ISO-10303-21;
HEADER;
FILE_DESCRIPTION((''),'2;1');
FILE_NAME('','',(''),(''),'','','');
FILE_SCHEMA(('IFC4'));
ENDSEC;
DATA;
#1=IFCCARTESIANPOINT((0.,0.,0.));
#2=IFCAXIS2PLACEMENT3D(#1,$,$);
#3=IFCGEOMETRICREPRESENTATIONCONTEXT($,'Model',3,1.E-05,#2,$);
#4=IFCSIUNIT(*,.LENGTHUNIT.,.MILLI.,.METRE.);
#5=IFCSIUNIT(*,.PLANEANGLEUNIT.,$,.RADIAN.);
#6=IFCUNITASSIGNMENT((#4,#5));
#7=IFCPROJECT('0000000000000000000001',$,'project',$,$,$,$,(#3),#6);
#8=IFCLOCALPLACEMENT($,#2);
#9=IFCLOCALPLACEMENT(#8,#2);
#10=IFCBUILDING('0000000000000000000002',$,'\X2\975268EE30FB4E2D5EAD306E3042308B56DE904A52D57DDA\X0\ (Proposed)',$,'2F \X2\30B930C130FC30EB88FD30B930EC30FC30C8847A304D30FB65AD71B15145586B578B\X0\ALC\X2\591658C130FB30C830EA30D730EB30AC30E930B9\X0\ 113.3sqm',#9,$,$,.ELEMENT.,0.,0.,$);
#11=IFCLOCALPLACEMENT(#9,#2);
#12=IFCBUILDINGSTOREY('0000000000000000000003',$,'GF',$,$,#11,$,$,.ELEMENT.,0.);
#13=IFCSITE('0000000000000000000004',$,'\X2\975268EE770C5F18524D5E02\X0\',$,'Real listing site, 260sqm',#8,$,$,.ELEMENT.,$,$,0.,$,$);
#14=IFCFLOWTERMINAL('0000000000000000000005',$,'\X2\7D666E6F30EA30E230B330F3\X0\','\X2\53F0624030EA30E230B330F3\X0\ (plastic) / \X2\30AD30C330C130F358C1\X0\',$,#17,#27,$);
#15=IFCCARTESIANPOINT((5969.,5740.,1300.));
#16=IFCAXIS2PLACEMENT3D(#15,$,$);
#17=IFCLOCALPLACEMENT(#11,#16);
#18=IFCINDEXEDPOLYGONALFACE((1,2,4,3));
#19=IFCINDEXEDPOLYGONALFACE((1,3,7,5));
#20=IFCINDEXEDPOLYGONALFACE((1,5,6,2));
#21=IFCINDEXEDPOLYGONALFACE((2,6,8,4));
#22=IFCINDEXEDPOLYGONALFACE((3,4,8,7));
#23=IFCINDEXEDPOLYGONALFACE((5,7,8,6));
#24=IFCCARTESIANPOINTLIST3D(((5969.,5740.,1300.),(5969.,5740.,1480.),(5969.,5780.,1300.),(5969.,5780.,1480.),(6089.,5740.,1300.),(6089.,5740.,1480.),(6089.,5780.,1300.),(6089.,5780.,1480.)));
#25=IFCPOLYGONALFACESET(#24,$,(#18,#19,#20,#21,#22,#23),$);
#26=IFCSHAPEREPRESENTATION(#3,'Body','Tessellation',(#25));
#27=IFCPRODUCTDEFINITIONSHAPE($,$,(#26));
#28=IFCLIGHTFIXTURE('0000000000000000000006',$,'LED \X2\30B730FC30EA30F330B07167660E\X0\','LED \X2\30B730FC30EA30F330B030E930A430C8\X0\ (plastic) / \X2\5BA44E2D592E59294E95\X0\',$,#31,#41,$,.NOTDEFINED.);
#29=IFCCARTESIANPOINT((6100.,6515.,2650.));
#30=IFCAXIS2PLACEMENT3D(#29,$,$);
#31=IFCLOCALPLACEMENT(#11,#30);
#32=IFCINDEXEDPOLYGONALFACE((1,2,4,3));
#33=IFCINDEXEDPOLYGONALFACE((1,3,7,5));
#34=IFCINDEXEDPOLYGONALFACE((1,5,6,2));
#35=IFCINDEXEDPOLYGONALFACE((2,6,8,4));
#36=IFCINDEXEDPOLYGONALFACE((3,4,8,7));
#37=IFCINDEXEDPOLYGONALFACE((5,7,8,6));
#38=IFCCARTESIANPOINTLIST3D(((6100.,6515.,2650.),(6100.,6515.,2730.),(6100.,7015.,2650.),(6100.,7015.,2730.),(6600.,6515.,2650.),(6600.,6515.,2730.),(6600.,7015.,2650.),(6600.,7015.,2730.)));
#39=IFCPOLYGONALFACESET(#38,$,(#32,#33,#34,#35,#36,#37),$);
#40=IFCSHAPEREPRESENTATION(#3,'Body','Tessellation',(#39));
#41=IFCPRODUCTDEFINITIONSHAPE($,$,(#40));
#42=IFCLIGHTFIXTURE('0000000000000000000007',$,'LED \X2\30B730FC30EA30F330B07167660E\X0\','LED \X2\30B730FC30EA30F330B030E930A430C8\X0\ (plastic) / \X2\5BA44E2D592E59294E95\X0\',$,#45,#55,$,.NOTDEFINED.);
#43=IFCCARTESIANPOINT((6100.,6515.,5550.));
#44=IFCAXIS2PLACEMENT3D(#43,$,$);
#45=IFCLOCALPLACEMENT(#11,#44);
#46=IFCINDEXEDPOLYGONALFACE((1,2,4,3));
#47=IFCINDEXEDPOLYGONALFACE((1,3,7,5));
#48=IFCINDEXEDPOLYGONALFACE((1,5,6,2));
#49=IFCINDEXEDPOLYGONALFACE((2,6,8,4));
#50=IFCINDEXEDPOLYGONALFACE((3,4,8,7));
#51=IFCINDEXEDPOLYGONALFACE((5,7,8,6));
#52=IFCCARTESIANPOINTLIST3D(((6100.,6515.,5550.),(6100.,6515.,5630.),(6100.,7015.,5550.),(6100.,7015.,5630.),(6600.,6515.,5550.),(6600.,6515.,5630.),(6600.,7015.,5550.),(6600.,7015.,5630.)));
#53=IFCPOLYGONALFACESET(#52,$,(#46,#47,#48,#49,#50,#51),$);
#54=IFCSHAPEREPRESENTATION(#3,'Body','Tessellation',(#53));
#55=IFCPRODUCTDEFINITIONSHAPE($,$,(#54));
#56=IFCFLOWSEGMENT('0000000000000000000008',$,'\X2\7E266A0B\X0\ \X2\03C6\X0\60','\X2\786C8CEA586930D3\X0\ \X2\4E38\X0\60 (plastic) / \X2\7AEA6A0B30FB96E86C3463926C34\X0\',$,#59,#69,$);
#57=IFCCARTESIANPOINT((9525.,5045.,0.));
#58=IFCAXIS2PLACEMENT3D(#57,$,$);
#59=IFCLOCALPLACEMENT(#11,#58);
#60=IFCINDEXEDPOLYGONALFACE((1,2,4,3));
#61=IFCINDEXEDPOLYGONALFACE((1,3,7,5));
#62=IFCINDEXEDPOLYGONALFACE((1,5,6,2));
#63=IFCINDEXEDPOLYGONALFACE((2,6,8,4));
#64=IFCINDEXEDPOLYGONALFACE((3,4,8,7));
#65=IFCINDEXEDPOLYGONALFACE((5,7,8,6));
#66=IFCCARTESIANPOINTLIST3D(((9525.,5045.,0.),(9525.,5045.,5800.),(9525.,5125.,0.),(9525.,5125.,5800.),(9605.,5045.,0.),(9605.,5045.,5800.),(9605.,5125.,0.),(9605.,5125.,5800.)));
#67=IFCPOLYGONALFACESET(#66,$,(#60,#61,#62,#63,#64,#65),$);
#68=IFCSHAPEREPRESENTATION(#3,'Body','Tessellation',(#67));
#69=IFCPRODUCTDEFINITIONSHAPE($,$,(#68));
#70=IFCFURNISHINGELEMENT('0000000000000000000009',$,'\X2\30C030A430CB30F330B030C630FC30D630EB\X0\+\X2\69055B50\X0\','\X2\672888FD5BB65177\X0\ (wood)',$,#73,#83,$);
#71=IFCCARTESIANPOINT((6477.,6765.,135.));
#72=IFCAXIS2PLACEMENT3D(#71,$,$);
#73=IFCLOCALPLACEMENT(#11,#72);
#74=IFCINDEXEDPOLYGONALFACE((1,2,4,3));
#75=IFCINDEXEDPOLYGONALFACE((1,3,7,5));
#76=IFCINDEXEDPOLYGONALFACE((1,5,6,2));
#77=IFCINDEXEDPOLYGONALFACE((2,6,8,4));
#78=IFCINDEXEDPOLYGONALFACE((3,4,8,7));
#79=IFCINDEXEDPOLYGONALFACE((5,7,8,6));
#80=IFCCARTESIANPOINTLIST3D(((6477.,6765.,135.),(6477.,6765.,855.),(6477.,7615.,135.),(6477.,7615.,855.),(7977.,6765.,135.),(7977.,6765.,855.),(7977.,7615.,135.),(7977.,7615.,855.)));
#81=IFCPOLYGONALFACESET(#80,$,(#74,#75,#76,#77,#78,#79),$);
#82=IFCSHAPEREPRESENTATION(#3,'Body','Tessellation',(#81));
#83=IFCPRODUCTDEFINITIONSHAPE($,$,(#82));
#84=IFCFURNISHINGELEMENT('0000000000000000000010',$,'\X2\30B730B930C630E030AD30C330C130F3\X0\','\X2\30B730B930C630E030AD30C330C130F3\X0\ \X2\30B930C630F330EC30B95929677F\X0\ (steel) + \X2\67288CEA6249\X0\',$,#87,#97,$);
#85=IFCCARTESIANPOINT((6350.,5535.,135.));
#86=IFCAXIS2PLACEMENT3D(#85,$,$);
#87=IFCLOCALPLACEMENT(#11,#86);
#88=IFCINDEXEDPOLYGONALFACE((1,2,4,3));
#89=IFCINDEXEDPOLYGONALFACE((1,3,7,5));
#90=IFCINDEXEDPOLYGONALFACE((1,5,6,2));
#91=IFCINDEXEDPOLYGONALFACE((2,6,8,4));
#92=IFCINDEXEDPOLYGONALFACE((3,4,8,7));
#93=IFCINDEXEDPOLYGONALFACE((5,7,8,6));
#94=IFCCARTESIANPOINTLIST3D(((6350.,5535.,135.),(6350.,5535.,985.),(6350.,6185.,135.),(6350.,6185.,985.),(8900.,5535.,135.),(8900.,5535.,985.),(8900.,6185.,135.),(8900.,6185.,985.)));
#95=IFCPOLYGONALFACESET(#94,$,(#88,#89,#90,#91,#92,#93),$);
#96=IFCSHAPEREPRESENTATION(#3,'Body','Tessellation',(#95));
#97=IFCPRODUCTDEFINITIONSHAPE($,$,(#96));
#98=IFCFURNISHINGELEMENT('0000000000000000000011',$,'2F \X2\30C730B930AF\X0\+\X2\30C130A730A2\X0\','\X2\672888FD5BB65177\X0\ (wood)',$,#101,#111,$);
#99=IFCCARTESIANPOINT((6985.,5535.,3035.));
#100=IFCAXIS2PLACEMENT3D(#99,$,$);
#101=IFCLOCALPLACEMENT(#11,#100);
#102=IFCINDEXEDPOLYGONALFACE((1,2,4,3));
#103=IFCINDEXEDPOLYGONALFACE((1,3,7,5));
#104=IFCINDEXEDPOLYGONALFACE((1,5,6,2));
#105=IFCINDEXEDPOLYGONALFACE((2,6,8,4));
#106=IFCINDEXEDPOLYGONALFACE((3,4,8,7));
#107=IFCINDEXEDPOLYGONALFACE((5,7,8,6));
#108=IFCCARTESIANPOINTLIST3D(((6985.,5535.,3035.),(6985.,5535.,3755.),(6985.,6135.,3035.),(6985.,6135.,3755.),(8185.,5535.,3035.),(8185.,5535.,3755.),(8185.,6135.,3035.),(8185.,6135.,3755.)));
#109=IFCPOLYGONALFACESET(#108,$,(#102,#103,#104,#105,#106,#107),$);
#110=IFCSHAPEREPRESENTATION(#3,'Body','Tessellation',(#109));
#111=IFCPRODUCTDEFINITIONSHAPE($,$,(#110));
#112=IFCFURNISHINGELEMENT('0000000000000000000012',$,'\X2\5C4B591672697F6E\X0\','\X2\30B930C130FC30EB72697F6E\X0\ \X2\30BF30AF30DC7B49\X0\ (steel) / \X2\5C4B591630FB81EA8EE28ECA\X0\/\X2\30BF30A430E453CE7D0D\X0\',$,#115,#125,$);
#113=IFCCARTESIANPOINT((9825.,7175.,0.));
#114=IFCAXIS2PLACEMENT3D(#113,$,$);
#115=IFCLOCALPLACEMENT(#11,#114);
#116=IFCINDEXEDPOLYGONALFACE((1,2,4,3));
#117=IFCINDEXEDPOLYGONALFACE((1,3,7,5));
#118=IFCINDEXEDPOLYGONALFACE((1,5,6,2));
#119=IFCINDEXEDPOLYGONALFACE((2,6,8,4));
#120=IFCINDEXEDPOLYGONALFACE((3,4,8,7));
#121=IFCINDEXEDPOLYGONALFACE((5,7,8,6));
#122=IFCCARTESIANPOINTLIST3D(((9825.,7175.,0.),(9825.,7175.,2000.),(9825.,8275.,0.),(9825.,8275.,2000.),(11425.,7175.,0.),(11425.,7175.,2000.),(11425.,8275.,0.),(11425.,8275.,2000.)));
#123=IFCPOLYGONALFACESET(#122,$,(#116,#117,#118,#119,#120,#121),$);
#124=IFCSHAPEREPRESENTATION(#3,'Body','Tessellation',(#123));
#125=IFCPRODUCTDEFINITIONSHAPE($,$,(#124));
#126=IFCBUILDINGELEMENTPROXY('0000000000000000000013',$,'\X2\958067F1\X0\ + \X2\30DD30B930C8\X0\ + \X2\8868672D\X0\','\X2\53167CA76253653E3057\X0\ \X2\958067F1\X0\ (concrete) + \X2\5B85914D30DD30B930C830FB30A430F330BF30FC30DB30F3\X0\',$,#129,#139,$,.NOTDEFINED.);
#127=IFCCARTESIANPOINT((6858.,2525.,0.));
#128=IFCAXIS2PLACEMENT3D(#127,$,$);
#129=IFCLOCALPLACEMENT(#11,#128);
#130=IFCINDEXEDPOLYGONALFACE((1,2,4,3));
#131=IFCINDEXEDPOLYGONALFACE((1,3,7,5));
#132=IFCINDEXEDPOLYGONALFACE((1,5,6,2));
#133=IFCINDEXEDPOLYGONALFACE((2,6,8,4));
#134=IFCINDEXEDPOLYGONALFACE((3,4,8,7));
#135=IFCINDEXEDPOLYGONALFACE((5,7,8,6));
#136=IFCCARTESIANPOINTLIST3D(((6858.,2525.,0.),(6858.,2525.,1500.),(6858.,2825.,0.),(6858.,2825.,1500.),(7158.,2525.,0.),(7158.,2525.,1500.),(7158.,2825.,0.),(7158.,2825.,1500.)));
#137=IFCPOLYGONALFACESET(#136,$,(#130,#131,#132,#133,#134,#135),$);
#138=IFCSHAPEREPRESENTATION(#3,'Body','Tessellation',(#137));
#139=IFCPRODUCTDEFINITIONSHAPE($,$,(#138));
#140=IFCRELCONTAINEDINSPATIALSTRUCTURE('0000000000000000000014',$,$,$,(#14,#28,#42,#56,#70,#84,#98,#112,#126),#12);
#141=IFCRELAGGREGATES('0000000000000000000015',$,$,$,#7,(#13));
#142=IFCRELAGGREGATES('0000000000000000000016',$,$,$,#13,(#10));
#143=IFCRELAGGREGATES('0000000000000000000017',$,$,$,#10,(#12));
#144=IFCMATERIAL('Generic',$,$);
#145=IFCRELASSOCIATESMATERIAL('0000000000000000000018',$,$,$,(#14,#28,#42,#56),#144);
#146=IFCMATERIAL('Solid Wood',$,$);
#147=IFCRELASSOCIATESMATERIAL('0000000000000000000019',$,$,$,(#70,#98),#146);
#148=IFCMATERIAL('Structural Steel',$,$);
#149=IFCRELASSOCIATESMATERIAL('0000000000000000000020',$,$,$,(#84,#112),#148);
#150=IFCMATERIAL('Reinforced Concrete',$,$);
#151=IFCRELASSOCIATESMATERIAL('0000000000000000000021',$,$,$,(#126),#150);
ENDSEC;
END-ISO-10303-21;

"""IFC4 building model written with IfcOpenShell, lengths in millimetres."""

from ifc_helpers import new_model, si_unit, frame, frame_2d, origin, place, context, project, spatial, rectangle, extrude, material, element, save


model = new_model("IFC4")

# Units and contexts
model_context = context("Model", 3, precision=1e-05, world=origin())
ifc_project = project(units=[si_unit("LENGTHUNIT", "METRE", prefix="MILLI"), si_unit("PLANEANGLEUNIT", "RADIAN")], contexts=[model_context])

# Site, building, storey
site_placement = place(None, origin())
site = spatial("IfcSite", under=ifc_project, at=site_placement, Name="青森県弘前市", ObjectType="Real listing site, 260sqm", CompositionType="ELEMENT", RefElevation=0.0)
building_placement = place(site_placement, origin())
building = spatial("IfcBuilding", under=site, at=building_placement, Name="青森・中庭のある回遊動線 (Proposed)", ObjectType="2F スチール製スレート葺き・断熱充填型ALC外壁・トリプルガラス 113.3sqm", CompositionType="ELEMENT", ElevationOfRefHeight=0.0, ElevationOfTerrain=0.0)
storey_placement = place(building_placement, origin())
storey = spatial("IfcBuildingStorey", under=building, at=storey_placement, Name="GF", CompositionType="ELEMENT", Elevation=0.0)

# Shared definitions
ifc_material_1 = material(Name="Solid Wood")

# Shared definitions
ifc_material_2 = material(Name="Reinforced Concrete")

# Shared definitions
ifc_material_3 = material(Name="Structural Steel")

# Flow terminal
ifc_material_4 = material(Name="Generic")
flow_terminal_1_placement = place(storey_placement, frame((5969.0, 5740.0, 1300.0)))
element("IfcFlowTerminal", 1, at=flow_terminal_1_placement, inside=storey, material=ifc_material_4, Name="給湯リモコン", Description="台所リモコン (plastic) / キッチン壁", context=model_context, shape_type="SweptSolid", body=[
    extrude(rectangle(XDim=120.0, YDim=40.0, at=frame_2d((60.0, 20.0))), frame((5969.0, 5740.0, 1300.0)), (0.0, 0.0, 1.0), 180.0),
])

# Light fixtures
light_fixture_1_placement = place(storey_placement, frame((6100.0, 6515.0, 2650.0)))
element("IfcLightFixture", 2, at=light_fixture_1_placement, inside=storey, material=ifc_material_4, Name="LED シーリング照明", Description="LED シーリングライト (plastic) / 室中央天井", PredefinedType="NOTDEFINED", context=model_context, shape_type="SweptSolid", body=[
    extrude(rectangle(XDim=500.0, YDim=500.0, at=frame_2d((250.0, 250.0))), frame((6100.0, 6515.0, 2650.0)), (0.0, 0.0, 1.0), 80.0),
])
light_fixture_2_placement = place(storey_placement, frame((6100.0, 6515.0, 5550.0)))
element("IfcLightFixture", 3, at=light_fixture_2_placement, inside=storey, material=ifc_material_4, Name="LED シーリング照明", Description="LED シーリングライト (plastic) / 室中央天井", PredefinedType="NOTDEFINED", context=model_context, shape_type="SweptSolid", body=[
    extrude(rectangle(XDim=500.0, YDim=500.0, at=frame_2d((250.0, 250.0))), frame((6100.0, 6515.0, 5550.0)), (0.0, 0.0, 1.0), 80.0),
])

# Flow segment
flow_segment_placement = place(storey_placement, frame((9525.0, 5045.0, 0.0)))
element("IfcFlowSegment", 4, at=flow_segment_placement, inside=storey, material=ifc_material_4, Name="縦樋 φ60", Description="硬質塩ビ 丸60 (plastic) / 竪樋・雨水排水", context=model_context, shape_type="SweptSolid", body=[
    extrude(rectangle(XDim=80.0, YDim=80.0, at=frame_2d((40.0, 40.0))), frame((9525.0, 5045.0, 0.0)), (0.0, 0.0, 1.0), 5800.0),
])

# Furnishing elements
furnishing_1_placement = place(storey_placement, frame((6477.0, 6765.0, 135.0)))
element("IfcFurnishingElement", 5, at=furnishing_1_placement, inside=storey, material=ifc_material_1, Name="ダイニングテーブル+椅子", Description="木製家具 (wood)", context=model_context, shape_type="SweptSolid", body=[
    extrude(rectangle(XDim=1500.0, YDim=850.0, at=frame_2d((750.0, 425.0))), frame((6477.0, 6765.0, 135.0)), (0.0, 0.0, 1.0), 720.0),
])
furnishing_2_placement = place(storey_placement, frame((6350.0, 5535.0, 135.0)))
element("IfcFurnishingElement", 6, at=furnishing_2_placement, inside=storey, material=ifc_material_3, Name="システムキッチン", Description="システムキッチン ステンレス天板 (steel) + 木質扉", context=model_context, shape_type="SweptSolid", body=[
    extrude(rectangle(XDim=2550.0, YDim=650.0, at=frame_2d((1275.0, 325.0))), frame((6350.0, 5535.0, 135.0)), (0.0, 0.0, 1.0), 850.0),
])
furnishing_3_placement = place(storey_placement, frame((6985.0, 5535.0, 3035.0)))
element("IfcFurnishingElement", 7, at=furnishing_3_placement, inside=storey, material=ifc_material_1, Name="2F デスク+チェア", Description="木製家具 (wood)", context=model_context, shape_type="SweptSolid", body=[
    extrude(rectangle(XDim=1200.0, YDim=600.0, at=frame_2d((600.0, 300.0))), frame((6985.0, 5535.0, 3035.0)), (0.0, 0.0, 1.0), 720.0),
])
furnishing_4_placement = place(storey_placement, frame((9825.0, 7175.0, 0.0)))
element("IfcFurnishingElement", 8, at=furnishing_4_placement, inside=storey, material=ifc_material_3, Name="屋外物置", Description="スチール物置 タクボ等 (steel) / 屋外・自転車/タイヤ収納", context=model_context, shape_type="SweptSolid", body=[
    extrude(rectangle(XDim=1600.0, YDim=1100.0, at=frame_2d((800.0, 550.0))), frame((9825.0, 7175.0, 0.0)), (0.0, 0.0, 1.0), 2000.0),
])

# Building element proxy
proxy_placement = place(storey_placement, frame((6858.0, 2525.0, 0.0)))
element("IfcBuildingElementProxy", 9, at=proxy_placement, inside=storey, material=ifc_material_2, Name="門柱 + ポスト + 表札", Description="化粧打放し 門柱 (concrete) + 宅配ポスト・インターホン", PredefinedType="NOTDEFINED", context=model_context, shape_type="SweptSolid", body=[
    extrude(rectangle(XDim=300.0, YDim=300.0, at=frame_2d((150.0, 150.0))), frame((6858.0, 2525.0, 0.0)), (0.0, 0.0, 1.0), 1500.0),
])

save(model, "model.ifc")
